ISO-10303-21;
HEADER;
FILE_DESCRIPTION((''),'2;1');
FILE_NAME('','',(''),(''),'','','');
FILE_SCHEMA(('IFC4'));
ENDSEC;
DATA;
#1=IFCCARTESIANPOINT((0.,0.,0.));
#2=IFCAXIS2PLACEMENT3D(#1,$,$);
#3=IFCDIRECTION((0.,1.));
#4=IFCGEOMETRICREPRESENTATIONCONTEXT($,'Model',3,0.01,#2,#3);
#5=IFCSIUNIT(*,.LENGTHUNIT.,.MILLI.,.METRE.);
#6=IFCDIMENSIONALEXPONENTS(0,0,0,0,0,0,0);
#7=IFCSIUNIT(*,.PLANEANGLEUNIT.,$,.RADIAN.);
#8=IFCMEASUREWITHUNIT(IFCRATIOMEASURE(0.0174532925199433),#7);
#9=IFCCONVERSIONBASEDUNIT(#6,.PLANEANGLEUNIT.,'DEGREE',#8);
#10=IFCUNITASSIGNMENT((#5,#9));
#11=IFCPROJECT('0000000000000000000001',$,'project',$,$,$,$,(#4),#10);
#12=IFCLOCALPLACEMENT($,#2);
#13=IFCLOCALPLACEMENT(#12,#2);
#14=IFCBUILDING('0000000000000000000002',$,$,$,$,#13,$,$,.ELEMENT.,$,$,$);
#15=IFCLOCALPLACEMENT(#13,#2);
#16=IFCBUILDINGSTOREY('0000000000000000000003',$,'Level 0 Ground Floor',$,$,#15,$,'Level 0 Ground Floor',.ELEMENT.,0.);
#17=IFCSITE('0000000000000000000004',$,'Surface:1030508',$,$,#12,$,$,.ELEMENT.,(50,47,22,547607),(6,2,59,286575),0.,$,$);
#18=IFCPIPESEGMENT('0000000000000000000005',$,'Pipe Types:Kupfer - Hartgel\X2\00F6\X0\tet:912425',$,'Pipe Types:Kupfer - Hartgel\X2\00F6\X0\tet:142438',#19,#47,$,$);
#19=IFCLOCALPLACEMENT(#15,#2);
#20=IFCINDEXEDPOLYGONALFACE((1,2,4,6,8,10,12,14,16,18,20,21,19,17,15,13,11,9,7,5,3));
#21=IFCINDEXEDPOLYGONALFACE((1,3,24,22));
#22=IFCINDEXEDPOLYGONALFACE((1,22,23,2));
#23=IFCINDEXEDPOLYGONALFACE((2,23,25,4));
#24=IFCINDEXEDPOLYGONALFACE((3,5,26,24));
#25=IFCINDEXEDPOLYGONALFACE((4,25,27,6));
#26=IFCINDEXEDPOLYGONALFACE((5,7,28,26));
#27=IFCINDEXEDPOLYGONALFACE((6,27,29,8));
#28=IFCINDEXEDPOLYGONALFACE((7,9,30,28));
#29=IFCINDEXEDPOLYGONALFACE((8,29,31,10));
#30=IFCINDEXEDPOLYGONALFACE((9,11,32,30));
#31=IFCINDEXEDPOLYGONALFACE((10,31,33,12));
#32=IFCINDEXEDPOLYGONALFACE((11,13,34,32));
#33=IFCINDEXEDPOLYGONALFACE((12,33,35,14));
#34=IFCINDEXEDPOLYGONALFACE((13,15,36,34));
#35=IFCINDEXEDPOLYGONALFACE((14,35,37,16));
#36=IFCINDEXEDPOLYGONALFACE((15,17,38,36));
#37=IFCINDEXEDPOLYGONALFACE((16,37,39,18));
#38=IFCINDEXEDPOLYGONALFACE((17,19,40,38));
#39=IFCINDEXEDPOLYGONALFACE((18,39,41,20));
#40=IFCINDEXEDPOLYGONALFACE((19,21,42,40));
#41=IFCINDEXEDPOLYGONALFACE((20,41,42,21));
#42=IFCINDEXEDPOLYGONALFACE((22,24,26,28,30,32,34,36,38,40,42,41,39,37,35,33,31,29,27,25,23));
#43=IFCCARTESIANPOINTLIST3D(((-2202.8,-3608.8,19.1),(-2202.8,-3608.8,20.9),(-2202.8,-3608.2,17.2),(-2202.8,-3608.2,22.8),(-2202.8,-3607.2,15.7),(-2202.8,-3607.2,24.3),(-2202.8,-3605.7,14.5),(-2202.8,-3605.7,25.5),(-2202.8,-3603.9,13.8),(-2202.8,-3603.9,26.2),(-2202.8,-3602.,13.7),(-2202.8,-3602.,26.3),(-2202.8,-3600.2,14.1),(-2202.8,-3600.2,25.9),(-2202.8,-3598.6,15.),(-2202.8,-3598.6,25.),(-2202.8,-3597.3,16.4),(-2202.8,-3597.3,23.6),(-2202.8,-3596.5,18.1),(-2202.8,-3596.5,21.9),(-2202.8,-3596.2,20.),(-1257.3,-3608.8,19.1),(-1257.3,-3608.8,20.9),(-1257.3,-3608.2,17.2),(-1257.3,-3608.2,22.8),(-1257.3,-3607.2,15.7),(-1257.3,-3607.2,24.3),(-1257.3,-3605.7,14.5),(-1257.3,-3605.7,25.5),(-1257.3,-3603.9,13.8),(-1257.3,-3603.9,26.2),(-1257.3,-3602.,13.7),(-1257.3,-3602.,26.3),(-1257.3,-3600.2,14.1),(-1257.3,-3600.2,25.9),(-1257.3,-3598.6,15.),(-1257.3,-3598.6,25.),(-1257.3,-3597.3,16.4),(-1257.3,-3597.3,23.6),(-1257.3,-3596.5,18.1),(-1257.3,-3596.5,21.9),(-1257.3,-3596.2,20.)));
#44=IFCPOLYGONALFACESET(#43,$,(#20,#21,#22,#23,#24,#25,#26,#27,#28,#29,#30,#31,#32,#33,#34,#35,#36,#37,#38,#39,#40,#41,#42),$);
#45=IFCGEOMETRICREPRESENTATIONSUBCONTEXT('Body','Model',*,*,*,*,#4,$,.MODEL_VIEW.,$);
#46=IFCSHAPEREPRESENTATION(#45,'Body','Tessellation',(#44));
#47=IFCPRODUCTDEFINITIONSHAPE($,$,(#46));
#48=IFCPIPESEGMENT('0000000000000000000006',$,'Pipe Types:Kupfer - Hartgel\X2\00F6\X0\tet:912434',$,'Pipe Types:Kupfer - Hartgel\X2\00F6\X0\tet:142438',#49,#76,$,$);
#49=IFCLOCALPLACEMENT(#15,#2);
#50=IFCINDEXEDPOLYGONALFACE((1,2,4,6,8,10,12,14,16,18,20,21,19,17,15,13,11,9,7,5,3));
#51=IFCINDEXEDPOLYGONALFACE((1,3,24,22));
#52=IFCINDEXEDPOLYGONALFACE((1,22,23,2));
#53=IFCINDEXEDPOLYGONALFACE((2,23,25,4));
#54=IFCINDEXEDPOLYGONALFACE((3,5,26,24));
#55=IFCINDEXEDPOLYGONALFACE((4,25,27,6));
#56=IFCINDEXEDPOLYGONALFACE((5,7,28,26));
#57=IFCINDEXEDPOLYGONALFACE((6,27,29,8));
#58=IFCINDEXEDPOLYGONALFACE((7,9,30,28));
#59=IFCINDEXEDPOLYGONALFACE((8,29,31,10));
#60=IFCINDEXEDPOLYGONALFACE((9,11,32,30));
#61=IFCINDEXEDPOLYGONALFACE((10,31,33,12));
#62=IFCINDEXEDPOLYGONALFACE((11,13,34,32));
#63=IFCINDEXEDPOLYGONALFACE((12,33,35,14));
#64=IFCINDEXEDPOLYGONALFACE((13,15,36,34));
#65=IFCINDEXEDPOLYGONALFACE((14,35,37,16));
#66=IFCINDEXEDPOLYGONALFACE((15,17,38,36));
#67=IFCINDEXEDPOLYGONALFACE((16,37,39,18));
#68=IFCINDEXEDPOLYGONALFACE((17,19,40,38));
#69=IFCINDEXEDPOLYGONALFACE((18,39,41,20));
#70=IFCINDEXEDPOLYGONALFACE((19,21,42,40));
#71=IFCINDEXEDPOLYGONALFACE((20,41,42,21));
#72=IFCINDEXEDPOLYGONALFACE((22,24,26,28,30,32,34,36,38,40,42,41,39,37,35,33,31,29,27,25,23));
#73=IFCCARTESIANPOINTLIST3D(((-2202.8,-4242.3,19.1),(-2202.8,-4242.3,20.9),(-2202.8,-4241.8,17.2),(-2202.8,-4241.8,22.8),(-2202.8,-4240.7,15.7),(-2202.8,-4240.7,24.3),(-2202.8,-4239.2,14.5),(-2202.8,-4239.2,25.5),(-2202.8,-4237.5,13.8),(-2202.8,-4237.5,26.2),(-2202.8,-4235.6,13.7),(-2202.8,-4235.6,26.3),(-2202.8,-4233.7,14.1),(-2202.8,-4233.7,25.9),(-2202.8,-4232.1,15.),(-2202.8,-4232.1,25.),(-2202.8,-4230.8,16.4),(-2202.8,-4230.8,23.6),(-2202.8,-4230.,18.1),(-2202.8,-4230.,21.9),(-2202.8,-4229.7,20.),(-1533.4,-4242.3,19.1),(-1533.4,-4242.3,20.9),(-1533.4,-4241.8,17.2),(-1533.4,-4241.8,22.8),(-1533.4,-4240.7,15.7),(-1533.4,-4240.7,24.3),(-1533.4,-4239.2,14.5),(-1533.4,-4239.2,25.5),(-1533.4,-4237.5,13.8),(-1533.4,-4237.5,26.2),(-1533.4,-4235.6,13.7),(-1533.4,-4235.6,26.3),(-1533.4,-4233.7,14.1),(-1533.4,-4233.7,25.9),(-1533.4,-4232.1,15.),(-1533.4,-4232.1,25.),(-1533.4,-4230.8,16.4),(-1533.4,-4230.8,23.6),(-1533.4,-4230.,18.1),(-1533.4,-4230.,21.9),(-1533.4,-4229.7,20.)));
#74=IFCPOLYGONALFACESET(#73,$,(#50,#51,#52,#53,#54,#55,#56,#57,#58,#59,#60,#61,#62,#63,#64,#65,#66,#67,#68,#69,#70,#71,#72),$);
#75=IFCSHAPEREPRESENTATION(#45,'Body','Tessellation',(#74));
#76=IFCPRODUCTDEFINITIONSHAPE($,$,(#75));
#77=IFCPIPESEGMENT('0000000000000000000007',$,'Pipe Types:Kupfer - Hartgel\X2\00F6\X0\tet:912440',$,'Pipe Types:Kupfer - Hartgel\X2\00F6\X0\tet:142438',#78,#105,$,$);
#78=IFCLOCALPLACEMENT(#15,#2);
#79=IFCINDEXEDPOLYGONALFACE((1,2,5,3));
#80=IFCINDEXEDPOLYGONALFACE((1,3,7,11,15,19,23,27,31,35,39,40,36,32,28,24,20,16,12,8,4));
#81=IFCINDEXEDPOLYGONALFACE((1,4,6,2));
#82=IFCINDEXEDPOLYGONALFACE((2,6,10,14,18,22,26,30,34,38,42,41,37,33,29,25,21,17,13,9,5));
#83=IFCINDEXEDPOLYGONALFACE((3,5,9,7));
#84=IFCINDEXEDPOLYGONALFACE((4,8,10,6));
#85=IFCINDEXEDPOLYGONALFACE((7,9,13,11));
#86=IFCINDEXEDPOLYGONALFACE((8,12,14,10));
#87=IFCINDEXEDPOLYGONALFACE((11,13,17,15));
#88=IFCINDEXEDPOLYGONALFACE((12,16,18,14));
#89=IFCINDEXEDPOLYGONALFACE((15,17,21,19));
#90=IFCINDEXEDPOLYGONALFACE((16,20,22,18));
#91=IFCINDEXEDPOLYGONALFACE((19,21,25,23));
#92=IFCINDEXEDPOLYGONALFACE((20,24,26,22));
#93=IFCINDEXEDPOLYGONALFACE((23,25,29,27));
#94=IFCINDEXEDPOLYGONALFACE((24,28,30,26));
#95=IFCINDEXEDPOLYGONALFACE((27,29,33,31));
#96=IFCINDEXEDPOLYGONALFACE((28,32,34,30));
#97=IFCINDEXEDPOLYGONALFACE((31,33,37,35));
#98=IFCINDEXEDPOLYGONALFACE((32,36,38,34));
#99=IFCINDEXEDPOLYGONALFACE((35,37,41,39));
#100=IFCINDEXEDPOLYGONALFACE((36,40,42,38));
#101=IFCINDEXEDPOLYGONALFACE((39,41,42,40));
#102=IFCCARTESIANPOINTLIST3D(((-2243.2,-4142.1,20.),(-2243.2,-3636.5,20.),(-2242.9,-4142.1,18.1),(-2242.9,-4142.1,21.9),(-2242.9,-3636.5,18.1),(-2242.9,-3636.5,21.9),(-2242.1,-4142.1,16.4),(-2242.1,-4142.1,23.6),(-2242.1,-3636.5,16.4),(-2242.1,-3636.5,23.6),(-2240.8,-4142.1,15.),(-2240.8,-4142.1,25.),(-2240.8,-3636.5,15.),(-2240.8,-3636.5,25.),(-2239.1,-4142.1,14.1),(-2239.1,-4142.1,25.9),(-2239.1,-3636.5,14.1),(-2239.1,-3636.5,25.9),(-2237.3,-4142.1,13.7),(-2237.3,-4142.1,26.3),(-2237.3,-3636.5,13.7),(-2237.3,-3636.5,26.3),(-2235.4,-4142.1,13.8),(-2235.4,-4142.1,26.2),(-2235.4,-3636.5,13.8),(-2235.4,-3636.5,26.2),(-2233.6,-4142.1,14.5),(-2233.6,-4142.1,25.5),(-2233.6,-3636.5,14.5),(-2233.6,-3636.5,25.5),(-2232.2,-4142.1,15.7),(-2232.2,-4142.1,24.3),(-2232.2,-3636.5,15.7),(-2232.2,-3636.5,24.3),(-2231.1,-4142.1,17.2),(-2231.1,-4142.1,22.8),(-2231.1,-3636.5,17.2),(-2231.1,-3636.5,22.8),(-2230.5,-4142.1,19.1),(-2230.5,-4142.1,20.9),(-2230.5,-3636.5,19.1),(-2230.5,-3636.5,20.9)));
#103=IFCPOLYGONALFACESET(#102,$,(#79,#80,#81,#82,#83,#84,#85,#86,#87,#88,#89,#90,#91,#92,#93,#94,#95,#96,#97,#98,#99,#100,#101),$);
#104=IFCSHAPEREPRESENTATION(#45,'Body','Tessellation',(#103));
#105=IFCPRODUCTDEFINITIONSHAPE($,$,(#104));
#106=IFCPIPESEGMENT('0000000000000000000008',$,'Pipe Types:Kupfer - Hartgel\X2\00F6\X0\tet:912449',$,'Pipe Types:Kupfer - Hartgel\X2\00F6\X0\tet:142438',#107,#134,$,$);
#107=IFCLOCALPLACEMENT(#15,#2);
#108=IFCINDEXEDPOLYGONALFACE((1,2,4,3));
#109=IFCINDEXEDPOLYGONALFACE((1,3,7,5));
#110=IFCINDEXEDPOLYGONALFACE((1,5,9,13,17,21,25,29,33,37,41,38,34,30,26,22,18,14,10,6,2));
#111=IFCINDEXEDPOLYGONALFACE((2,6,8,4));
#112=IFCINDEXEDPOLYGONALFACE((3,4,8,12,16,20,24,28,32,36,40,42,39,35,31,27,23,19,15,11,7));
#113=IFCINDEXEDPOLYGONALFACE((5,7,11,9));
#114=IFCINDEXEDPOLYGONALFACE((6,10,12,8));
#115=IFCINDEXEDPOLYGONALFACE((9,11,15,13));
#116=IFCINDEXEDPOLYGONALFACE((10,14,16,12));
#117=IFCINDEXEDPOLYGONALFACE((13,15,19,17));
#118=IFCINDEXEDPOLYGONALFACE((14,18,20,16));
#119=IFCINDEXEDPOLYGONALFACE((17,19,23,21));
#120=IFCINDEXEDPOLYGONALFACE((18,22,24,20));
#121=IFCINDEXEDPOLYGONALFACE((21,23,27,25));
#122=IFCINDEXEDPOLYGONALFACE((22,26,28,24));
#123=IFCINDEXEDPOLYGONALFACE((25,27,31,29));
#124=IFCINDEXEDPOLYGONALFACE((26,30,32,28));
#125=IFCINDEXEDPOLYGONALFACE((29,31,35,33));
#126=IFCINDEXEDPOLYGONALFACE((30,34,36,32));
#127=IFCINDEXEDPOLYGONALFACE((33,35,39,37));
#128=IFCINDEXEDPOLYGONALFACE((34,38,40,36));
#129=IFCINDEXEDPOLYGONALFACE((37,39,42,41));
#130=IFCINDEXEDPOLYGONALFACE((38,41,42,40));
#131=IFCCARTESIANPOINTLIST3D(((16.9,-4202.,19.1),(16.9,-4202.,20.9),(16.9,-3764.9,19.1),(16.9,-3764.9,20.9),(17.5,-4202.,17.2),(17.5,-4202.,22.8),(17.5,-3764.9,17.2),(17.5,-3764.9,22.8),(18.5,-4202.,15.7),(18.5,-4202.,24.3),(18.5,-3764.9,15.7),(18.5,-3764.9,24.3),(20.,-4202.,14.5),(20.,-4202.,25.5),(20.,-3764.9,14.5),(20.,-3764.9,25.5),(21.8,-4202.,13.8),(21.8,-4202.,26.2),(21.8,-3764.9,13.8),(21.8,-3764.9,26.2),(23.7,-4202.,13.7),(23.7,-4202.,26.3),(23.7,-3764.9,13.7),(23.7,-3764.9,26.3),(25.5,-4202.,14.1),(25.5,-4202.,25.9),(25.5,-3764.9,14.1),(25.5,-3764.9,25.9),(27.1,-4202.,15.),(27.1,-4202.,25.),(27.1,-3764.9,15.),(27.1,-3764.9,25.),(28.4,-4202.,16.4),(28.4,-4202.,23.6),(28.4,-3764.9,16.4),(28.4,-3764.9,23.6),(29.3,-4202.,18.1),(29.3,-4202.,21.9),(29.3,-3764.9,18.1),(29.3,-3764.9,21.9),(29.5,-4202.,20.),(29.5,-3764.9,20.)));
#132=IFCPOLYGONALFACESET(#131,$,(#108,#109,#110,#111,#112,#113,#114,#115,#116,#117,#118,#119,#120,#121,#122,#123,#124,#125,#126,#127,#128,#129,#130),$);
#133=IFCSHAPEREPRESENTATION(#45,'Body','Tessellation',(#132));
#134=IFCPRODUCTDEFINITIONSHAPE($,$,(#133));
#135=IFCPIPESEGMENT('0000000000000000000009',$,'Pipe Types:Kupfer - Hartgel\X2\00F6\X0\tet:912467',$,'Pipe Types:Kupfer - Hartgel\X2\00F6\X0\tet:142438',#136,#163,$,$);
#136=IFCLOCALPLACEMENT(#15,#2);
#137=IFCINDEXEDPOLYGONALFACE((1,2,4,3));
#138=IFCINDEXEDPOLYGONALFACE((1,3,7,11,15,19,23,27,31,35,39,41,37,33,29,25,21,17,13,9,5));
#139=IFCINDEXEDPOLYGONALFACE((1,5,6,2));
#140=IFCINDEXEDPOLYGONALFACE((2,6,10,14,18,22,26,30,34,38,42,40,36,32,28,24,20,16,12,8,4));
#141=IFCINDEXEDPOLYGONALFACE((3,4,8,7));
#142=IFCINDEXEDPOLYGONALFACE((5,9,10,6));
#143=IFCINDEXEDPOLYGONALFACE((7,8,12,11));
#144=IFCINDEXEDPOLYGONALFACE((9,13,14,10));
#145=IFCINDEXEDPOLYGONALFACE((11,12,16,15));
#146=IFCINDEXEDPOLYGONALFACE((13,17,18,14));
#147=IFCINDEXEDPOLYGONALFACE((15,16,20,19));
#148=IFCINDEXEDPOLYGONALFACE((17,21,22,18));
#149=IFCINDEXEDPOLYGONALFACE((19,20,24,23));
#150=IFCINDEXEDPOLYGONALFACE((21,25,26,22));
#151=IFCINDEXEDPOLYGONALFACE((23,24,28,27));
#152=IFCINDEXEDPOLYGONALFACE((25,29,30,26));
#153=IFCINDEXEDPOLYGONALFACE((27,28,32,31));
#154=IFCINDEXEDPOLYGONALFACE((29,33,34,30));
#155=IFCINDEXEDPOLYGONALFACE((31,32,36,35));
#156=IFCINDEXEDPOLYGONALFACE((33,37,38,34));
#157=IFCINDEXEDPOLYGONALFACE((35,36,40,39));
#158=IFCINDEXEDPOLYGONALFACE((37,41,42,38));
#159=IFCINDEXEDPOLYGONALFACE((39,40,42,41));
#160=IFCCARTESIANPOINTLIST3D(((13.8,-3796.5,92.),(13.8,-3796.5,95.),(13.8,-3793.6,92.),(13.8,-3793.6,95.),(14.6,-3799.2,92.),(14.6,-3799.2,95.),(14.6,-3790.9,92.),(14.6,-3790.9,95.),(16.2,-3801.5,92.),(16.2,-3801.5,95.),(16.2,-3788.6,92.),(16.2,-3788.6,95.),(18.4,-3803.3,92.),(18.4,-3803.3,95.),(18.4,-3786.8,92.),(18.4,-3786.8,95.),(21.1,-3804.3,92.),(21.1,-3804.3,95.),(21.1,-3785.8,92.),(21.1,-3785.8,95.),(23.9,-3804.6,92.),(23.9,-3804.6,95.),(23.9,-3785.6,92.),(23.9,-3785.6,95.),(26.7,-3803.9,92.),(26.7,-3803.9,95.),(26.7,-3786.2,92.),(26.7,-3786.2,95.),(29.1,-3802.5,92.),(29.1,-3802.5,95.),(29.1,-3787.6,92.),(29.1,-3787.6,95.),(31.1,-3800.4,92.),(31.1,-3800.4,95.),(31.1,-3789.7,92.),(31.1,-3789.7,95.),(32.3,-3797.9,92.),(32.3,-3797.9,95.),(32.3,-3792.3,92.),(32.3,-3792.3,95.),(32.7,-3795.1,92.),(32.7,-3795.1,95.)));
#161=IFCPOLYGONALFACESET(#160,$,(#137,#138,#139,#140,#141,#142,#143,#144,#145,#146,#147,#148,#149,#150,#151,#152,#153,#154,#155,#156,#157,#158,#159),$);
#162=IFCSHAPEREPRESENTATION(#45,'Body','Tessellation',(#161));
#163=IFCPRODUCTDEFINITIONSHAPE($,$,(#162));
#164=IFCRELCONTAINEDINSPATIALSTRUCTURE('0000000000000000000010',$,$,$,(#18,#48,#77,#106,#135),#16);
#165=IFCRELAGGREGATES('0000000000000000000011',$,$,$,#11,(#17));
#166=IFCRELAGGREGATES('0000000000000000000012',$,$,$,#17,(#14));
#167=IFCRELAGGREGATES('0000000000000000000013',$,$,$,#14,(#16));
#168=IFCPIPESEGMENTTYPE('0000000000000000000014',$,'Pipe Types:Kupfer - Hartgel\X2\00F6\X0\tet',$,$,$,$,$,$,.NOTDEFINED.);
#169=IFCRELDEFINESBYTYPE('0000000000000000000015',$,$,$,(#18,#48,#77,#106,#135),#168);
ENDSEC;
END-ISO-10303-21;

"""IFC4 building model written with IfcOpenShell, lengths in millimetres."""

from ifc_helpers import new_model, entity, si_unit, converted_unit, direction, frame, frame_2d, origin, place, context, subcontext, project, spatial, circle, extrude, type_object, element, save


model = new_model("IFC4")

# Units and contexts
model_context = context("Model", 3, precision=0.01, world=origin(), true_north=direction((0.0, 1.0)))
body_context = subcontext(model_context, "Body", "Model", "MODEL_VIEW")
ifc_project = project(units=[si_unit("LENGTHUNIT", "METRE", prefix="MILLI"), converted_unit("PLANEANGLEUNIT", "DEGREE", entity("IfcRatioMeasure", 0.0174532925199433), si_unit("PLANEANGLEUNIT", "RADIAN"), dimensions=[0, 0, 0, 0, 0, 0, 0])], contexts=[model_context])

# Site, building, storey
site_placement = place(None, origin())
site = spatial("IfcSite", under=ifc_project, at=site_placement, Name="Surface:1030508", CompositionType="ELEMENT", RefLatitude=(50, 47, 22, 547607), RefLongitude=(6, 2, 59, 286575), RefElevation=0.0)
building_placement = place(site_placement, origin())
building = spatial("IfcBuilding", under=site, at=building_placement, CompositionType="ELEMENT")
storey_placement = place(building_placement, origin())
storey = spatial("IfcBuildingStorey", under=building, at=storey_placement, Name="Level 0 Ground Floor", LongName="Level 0 Ground Floor", CompositionType="ELEMENT", Elevation=0.0)

# Pipe segments
pipe_segment_type = type_object("IfcPipeSegmentType", Name="Pipe Types:Kupfer - Hartgelötet", PredefinedType="NOTDEFINED")
pipe_segment_1_placement = place(storey_placement, frame((-2202.8, -3610.5, 12.1)))
element("IfcPipeSegment", 1, at=pipe_segment_1_placement, inside=storey, type_object=pipe_segment_type, Name="Pipe Types:Kupfer - Hartgelötet:912425", ObjectType="Pipe Types:Kupfer - Hartgelötet:142438", context=body_context, shape_type="SweptSolid", body=[
    extrude(circle(Radius=6.3, at=frame_2d((0.0, 0.0), x_axis=(1.0, 0.0))), frame((0.0, 7.9, 7.9), z_axis=(1.0, 0.0, 0.0), x_axis=(0.0, 1.0, 0.0)), (0.0, 0.0, 1.0), 945.5),
])
pipe_segment_2_placement = place(storey_placement, frame((-2202.8, -4244.0, 12.1)))
element("IfcPipeSegment", 2, at=pipe_segment_2_placement, inside=storey, type_object=pipe_segment_type, Name="Pipe Types:Kupfer - Hartgelötet:912434", ObjectType="Pipe Types:Kupfer - Hartgelötet:142438", context=body_context, shape_type="SweptSolid", body=[
    extrude(circle(Radius=6.3, at=frame_2d((0.0, 0.0), x_axis=(1.0, 0.0))), frame((0.0, 7.9, 7.9), z_axis=(1.0, 0.000044, 0.0), x_axis=(-0.000044, 1.0, 0.0)), (0.0, 0.0, 1.0), 669.4),
])
pipe_segment_3_placement = place(storey_placement, frame((-2244.8, -4142.1, 12.1)))
element("IfcPipeSegment", 3, at=pipe_segment_3_placement, inside=storey, type_object=pipe_segment_type, Name="Pipe Types:Kupfer - Hartgelötet:912440", ObjectType="Pipe Types:Kupfer - Hartgelötet:142438", context=body_context, shape_type="SweptSolid", body=[
    extrude(circle(Radius=6.3, at=frame_2d((0.0, 0.0), x_axis=(1.0, 0.0))), frame((7.9, 0.0, 7.9), z_axis=(0.0, 1.0, 0.0), x_axis=(-1.0, 0.0, 0.0)), (0.0, 0.0, 1.0), 505.5),
])
pipe_segment_4_placement = place(storey_placement, frame((15.2, -4202.0, 12.1)))
element("IfcPipeSegment", 4, at=pipe_segment_4_placement, inside=storey, type_object=pipe_segment_type, Name="Pipe Types:Kupfer - Hartgelötet:912449", ObjectType="Pipe Types:Kupfer - Hartgelötet:142438", context=body_context, shape_type="SweptSolid", body=[
    extrude(circle(Radius=6.3, at=frame_2d((0.0, 0.0), x_axis=(1.0, 0.0))), frame((7.9, 0.0, 7.9), z_axis=(0.0, 1.0, 0.0), x_axis=(1.0, 0.0, 0.0)), (0.0, 0.0, 1.0), 437.1),
])
pipe_segment_5_placement = place(storey_placement, frame((12.1, -3806.2, 92.0)))
element("IfcPipeSegment", 5, at=pipe_segment_5_placement, inside=storey, type_object=pipe_segment_type, Name="Pipe Types:Kupfer - Hartgelötet:912467", ObjectType="Pipe Types:Kupfer - Hartgelötet:142438", context=body_context, shape_type="SweptSolid", body=[
    extrude(circle(Radius=9.5, at=frame_2d((0.0, 0.0), x_axis=(1.0, 0.0))), frame((11.1, 11.1, 0.0)), (0.0, 0.0, 1.0), 3.0),
])

save(model, "model.ifc")
